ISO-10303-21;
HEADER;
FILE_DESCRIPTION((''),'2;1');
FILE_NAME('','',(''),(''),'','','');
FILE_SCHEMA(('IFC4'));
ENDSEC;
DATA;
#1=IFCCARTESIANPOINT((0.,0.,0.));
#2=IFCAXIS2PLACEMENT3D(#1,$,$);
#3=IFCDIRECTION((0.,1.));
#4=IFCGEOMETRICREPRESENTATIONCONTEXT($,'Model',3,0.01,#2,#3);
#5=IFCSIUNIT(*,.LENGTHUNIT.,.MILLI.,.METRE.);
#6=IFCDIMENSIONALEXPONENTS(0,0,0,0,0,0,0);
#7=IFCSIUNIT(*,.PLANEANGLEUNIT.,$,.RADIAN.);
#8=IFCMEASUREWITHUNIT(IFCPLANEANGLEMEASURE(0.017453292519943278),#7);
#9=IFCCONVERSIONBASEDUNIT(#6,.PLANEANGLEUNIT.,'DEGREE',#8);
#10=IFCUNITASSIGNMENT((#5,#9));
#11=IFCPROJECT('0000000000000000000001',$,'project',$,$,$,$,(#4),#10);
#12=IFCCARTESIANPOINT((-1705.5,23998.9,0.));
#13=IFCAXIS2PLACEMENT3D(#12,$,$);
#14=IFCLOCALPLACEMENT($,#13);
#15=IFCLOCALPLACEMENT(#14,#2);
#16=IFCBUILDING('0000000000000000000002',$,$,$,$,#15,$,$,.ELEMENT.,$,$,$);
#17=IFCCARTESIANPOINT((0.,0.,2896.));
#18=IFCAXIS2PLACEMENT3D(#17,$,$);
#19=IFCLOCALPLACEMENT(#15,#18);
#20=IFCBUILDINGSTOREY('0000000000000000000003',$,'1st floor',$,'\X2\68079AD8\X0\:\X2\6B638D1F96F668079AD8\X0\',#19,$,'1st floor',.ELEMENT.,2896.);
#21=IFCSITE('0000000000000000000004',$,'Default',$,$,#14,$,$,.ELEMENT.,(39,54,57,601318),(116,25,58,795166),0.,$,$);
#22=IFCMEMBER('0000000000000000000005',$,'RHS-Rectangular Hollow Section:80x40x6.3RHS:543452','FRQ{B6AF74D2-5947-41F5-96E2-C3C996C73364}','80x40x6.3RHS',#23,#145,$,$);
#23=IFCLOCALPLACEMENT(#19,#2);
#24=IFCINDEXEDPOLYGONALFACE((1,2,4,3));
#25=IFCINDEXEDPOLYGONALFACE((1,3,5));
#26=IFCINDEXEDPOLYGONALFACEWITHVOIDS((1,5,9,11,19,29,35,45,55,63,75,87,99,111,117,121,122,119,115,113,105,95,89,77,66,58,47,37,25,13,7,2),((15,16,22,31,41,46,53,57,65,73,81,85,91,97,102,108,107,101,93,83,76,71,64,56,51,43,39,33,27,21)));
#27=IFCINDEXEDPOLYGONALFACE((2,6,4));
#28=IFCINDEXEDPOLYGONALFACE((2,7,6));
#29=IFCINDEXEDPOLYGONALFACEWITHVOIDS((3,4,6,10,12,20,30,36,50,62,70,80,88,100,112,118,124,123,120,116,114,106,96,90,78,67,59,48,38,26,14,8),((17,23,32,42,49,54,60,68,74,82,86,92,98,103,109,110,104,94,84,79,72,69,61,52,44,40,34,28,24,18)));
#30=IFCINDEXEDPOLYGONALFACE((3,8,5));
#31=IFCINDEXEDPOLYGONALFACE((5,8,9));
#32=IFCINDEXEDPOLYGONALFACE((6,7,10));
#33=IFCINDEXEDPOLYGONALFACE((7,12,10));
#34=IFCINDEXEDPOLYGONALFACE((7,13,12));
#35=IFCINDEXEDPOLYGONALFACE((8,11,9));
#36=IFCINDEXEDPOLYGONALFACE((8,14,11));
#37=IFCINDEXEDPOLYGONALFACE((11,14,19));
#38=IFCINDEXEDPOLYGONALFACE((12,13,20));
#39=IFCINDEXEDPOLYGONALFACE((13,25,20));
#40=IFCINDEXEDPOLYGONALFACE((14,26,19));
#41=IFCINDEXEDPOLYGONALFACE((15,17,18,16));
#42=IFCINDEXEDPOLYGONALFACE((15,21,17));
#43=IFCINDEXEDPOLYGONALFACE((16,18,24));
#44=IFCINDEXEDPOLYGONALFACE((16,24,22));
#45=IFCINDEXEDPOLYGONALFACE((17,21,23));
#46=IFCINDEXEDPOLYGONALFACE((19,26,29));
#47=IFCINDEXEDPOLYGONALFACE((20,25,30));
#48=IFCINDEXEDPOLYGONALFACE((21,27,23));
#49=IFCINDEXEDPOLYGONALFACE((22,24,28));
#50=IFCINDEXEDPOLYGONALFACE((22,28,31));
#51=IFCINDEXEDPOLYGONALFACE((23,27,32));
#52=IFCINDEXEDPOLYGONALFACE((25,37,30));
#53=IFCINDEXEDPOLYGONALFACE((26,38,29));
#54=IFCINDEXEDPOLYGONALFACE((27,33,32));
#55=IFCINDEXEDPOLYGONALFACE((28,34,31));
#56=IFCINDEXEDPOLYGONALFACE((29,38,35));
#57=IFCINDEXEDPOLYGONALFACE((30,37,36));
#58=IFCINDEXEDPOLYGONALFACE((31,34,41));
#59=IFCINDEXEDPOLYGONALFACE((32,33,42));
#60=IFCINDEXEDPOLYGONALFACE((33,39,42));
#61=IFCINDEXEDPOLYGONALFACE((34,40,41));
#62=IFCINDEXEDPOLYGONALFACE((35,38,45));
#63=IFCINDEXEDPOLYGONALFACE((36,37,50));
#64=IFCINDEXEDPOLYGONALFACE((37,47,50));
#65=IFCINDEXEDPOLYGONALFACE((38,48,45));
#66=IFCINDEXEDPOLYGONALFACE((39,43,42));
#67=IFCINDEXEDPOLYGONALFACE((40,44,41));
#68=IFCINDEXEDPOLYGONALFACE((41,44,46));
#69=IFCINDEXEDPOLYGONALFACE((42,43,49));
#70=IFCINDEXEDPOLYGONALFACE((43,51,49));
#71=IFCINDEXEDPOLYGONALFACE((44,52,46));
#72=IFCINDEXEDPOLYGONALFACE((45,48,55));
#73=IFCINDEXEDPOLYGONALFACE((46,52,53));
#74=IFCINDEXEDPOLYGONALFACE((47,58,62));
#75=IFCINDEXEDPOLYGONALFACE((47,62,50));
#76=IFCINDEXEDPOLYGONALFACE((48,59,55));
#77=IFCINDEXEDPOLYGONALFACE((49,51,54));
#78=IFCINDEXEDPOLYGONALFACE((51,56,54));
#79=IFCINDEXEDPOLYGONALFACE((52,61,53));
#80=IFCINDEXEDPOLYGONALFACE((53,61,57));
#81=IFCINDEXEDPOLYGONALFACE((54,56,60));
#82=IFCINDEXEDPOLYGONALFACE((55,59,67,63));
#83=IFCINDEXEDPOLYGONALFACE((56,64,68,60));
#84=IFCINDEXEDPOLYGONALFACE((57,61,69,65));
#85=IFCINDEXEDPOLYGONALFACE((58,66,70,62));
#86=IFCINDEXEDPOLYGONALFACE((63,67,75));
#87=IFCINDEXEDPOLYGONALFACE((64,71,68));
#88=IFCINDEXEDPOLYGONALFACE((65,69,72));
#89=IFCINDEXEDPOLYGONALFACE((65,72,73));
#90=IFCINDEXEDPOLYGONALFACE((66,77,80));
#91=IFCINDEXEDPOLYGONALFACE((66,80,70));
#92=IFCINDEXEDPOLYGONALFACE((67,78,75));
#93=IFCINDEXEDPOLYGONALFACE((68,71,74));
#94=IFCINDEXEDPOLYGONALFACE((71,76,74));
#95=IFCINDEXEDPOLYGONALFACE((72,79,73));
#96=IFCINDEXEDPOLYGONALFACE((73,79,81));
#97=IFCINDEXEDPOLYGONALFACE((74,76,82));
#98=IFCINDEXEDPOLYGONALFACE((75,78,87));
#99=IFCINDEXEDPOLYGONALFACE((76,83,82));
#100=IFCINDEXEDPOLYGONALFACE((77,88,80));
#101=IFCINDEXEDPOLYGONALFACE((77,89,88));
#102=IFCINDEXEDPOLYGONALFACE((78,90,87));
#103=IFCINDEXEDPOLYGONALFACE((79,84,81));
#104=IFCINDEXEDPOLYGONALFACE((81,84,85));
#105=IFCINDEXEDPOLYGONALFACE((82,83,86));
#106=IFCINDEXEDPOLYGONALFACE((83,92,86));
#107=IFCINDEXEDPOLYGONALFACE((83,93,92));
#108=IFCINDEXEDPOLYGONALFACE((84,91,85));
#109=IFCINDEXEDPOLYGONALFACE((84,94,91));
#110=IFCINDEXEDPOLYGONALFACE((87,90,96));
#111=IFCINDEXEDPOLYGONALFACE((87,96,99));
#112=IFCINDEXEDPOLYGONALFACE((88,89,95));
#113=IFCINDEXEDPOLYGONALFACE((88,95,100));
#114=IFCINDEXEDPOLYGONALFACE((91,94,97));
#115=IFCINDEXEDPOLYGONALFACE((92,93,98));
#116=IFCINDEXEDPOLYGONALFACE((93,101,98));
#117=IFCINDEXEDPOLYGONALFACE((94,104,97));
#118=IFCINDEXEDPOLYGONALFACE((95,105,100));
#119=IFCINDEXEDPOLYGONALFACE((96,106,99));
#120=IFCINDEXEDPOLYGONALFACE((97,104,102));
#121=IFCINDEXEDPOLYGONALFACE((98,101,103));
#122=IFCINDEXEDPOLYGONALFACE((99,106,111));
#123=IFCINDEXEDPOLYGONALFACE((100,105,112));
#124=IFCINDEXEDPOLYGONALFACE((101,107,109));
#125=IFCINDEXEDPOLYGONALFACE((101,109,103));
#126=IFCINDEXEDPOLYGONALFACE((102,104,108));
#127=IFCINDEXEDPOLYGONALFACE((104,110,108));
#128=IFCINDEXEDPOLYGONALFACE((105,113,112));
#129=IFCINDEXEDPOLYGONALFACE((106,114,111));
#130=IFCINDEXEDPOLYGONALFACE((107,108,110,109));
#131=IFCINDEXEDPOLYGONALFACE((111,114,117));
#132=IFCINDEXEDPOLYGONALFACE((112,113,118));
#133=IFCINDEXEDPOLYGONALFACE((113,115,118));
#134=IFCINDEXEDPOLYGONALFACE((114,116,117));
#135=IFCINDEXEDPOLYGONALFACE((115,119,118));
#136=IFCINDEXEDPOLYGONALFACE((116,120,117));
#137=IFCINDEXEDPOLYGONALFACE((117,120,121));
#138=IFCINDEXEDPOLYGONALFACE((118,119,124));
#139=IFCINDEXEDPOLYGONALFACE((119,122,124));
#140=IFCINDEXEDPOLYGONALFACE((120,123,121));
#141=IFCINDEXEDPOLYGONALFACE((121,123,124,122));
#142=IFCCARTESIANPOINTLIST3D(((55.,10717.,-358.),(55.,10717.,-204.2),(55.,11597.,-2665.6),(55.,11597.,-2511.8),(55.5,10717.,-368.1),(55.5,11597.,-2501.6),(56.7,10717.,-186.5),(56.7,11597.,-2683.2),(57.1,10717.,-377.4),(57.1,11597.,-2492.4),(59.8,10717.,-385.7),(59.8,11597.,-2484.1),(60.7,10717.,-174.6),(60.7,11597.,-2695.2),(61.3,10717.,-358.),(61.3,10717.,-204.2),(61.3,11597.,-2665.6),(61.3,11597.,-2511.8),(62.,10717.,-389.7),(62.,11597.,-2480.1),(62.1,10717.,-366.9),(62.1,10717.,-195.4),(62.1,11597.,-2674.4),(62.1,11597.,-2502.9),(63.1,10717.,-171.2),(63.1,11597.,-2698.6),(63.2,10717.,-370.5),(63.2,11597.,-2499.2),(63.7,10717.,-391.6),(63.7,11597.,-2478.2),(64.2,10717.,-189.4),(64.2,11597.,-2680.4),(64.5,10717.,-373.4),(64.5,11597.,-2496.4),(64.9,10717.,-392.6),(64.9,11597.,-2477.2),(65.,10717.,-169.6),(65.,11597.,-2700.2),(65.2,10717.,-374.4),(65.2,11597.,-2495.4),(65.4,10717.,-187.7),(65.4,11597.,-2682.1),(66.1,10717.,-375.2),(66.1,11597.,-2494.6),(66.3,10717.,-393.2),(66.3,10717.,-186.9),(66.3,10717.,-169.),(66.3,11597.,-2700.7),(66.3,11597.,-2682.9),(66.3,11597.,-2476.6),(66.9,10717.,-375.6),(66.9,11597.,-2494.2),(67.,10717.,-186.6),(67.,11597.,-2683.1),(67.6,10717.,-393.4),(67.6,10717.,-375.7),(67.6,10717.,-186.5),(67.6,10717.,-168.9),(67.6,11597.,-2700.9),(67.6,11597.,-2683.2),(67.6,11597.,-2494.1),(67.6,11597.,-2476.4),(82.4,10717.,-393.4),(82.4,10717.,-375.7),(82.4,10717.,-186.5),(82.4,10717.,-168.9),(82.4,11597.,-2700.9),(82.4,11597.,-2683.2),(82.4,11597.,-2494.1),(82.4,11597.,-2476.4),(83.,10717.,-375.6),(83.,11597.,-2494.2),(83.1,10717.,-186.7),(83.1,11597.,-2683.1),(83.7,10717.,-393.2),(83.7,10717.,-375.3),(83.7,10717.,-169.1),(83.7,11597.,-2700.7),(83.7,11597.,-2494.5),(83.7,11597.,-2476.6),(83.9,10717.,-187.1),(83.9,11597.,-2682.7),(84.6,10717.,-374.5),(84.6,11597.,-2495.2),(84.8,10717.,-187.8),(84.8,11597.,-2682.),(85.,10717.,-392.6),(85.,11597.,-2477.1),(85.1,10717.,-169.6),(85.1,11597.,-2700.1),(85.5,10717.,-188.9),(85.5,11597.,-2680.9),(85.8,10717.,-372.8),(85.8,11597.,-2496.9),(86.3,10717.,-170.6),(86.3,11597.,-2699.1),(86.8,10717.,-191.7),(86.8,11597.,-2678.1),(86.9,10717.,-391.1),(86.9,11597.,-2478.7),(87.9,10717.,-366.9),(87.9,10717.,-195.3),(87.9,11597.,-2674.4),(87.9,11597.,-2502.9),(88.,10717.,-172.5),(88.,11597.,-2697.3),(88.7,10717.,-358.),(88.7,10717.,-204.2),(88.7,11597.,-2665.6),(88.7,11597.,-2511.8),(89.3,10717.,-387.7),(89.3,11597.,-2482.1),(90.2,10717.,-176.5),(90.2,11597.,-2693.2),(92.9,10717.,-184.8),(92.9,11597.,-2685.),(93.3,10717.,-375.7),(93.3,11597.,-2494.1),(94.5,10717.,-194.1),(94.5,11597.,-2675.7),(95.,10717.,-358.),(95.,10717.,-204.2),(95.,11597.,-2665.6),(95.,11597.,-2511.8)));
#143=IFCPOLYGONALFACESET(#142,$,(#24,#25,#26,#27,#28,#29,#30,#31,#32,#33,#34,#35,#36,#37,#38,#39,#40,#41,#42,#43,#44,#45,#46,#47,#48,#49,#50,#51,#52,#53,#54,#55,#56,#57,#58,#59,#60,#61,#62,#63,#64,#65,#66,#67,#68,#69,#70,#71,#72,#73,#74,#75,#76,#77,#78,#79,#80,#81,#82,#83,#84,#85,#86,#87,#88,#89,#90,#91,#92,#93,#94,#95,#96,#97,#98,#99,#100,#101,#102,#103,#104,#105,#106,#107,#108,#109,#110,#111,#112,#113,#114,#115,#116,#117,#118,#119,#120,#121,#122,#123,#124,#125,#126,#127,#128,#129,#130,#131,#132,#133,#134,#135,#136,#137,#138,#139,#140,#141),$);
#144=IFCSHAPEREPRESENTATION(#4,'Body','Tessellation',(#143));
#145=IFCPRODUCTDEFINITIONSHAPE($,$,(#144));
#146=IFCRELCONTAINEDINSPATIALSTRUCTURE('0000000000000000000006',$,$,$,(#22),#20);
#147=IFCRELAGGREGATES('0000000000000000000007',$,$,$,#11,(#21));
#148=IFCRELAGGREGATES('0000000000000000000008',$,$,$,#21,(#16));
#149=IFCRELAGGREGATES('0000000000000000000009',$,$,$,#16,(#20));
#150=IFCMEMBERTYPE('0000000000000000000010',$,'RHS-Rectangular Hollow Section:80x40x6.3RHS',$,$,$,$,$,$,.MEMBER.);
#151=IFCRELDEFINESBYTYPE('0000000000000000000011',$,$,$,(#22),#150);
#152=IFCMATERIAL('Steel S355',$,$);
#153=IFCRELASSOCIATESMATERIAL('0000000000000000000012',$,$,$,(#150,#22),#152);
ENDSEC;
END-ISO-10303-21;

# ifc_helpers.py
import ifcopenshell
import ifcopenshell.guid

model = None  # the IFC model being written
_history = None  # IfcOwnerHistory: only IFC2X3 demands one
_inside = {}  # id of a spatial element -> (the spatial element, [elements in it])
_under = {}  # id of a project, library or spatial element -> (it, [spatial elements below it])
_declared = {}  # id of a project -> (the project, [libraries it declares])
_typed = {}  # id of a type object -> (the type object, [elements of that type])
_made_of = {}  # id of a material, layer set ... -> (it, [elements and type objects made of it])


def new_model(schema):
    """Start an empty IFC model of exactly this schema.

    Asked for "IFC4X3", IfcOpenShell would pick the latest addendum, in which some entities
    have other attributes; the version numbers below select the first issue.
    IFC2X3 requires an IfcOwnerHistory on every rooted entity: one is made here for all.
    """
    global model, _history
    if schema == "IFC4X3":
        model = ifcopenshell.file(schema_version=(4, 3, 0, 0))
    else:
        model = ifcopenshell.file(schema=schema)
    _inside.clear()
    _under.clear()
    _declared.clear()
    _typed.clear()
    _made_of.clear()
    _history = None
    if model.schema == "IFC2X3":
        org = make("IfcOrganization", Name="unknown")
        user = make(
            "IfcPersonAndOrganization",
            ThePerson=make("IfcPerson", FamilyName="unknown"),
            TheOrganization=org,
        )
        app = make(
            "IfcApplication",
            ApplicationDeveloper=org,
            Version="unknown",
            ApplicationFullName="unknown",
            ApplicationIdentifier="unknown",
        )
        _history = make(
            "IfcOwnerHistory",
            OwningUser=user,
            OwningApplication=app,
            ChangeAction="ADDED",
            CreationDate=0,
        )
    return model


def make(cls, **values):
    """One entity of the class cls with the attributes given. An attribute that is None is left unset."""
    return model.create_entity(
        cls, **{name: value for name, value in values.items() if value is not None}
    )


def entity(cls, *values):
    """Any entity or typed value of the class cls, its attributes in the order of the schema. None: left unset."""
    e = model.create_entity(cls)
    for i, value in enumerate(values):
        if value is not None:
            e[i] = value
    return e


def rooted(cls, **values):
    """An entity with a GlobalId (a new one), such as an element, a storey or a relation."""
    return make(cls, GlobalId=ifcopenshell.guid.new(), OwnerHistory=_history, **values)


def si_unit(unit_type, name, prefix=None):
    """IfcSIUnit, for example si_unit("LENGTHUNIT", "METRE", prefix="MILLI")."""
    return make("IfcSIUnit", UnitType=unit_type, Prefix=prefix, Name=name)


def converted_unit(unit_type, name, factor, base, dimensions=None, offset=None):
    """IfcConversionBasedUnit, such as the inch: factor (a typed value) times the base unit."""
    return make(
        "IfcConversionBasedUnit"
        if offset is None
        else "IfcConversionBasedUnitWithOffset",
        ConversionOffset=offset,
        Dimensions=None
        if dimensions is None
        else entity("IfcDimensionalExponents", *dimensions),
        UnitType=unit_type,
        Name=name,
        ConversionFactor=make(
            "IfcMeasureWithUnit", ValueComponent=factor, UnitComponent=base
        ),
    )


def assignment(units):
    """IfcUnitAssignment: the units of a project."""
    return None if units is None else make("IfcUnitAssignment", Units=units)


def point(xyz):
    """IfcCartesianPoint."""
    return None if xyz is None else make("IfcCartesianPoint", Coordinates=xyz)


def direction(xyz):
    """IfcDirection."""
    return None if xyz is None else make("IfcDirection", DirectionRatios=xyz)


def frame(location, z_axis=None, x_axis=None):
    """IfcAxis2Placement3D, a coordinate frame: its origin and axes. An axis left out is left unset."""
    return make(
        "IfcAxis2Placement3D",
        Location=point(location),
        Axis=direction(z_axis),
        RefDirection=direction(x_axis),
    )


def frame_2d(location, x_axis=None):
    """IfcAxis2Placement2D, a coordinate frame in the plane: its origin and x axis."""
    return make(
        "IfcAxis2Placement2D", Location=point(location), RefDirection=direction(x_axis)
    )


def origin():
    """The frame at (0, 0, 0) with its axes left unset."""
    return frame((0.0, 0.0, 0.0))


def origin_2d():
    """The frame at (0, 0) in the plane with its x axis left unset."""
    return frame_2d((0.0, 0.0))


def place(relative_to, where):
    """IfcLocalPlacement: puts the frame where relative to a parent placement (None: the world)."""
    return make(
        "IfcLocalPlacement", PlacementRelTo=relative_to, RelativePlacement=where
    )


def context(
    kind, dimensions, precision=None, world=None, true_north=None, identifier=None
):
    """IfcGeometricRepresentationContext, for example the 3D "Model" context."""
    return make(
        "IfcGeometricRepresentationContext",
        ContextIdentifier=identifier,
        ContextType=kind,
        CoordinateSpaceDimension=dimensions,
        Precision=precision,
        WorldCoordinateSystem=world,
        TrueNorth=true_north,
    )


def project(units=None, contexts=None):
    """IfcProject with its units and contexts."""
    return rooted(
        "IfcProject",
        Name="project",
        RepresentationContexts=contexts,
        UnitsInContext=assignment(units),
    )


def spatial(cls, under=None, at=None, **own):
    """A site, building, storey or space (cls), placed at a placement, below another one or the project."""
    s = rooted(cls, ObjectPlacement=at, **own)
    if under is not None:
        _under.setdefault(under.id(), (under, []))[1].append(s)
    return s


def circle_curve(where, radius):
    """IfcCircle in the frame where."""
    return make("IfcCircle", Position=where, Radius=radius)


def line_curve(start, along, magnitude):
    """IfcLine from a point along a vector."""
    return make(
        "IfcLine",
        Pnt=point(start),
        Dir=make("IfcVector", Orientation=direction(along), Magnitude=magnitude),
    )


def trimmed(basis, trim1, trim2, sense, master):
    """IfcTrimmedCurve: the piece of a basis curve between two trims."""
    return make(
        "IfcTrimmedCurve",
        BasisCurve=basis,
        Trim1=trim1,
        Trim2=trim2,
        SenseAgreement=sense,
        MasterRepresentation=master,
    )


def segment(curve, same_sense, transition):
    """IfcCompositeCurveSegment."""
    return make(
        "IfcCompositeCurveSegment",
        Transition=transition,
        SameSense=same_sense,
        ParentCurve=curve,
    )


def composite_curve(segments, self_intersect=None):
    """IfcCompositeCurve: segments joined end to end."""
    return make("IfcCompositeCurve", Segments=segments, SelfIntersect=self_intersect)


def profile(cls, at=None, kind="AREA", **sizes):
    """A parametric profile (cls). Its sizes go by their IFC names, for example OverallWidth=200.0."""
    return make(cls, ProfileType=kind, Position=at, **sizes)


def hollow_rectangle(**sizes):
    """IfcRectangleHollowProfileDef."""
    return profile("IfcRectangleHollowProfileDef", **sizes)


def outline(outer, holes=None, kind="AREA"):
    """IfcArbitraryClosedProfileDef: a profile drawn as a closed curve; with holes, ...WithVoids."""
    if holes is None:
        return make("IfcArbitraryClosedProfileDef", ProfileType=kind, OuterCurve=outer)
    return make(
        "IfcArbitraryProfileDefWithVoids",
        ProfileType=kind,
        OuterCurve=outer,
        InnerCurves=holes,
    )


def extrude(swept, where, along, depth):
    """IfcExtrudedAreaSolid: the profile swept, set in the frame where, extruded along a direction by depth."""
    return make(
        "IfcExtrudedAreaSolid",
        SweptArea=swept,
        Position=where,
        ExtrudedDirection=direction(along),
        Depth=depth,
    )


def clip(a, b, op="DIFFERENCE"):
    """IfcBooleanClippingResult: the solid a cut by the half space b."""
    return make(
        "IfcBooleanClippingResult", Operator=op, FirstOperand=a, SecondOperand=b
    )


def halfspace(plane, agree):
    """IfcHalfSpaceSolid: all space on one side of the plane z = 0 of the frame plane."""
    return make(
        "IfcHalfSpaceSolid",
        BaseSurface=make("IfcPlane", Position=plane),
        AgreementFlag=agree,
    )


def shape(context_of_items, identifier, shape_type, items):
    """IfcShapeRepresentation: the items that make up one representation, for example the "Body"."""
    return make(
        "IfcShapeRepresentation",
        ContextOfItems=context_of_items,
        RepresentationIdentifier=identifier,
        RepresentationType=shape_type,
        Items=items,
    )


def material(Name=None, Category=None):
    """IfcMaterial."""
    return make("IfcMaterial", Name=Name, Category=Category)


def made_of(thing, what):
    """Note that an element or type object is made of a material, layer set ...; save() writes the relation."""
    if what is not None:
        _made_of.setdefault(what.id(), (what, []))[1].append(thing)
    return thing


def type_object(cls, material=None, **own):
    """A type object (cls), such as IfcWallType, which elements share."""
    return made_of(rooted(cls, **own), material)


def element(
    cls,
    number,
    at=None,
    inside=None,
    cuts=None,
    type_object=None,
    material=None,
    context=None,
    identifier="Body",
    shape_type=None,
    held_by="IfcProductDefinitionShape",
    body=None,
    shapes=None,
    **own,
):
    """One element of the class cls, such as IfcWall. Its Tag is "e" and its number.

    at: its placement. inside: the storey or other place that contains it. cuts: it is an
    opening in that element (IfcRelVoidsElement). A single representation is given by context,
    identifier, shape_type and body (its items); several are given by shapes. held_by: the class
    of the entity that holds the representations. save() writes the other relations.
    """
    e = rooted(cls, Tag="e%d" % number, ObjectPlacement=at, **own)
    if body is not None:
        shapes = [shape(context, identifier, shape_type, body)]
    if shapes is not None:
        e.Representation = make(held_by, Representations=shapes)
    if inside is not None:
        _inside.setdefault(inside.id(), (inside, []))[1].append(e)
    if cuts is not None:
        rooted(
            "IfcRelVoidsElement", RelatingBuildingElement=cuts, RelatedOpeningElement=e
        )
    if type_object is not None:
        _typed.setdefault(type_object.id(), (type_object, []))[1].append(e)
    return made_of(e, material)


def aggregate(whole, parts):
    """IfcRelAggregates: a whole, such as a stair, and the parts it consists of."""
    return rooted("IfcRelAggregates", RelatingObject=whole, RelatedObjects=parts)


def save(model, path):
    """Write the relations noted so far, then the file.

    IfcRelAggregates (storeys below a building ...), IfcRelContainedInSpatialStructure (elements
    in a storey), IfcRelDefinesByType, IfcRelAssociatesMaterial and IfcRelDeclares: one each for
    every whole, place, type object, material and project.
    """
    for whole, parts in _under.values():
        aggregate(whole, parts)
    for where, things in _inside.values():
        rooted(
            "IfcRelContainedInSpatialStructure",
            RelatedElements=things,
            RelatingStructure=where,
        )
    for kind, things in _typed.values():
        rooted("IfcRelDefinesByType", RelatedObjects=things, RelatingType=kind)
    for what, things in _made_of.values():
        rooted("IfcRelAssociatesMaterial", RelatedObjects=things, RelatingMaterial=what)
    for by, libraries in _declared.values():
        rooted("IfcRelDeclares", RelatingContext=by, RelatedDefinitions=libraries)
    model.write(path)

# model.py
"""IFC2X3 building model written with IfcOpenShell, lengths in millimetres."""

from ifc_helpers import new_model, entity, si_unit, converted_unit, point, direction, frame, frame_2d, origin, origin_2d, place, context, project, spatial, circle_curve, line_curve, trimmed, segment, composite_curve, hollow_rectangle, outline, extrude, clip, halfspace, material, type_object, element, save


model = new_model("IFC2X3")

# Units and contexts
model_context = context("Model", 3, precision=0.01, world=origin(), true_north=direction((0.0, 1.0)))
ifc_project = project(units=[si_unit("LENGTHUNIT", "METRE", prefix="MILLI"), converted_unit("PLANEANGLEUNIT", "DEGREE", entity("IfcPlaneAngleMeasure", 0.017453292519943278), si_unit("PLANEANGLEUNIT", "RADIAN"), dimensions=[0, 0, 0, 0, 0, 0, 0])], contexts=[model_context])

# Site, building, storey
site_placement = place(None, frame((-1705.5, 23998.9, 0.0)))
site = spatial("IfcSite", under=ifc_project, at=site_placement, Name="Default", CompositionType="ELEMENT", RefLatitude=(39, 54, 57, 601318), RefLongitude=(116, 25, 58, 795166), RefElevation=0.0)
building_placement = place(site_placement, origin())
building = spatial("IfcBuilding", under=site, at=building_placement, CompositionType="ELEMENT")
storey_placement = place(building_placement, frame((0.0, 0.0, 2896.0)))
storey = spatial("IfcBuildingStorey", under=building, at=storey_placement, Name="1st floor", ObjectType="标高:正负零标高", LongName="1st floor", CompositionType="ELEMENT", Elevation=2896.0)

# Shared definitions
ifc_material_1 = material(Name="Steel S355")

# Member, opening
member_type = type_object("IfcMemberType", Name="RHS-Rectangular Hollow Section:80x40x6.3RHS", PredefinedType="MEMBER", material=ifc_material_1)
member_1_placement = place(storey_placement, frame((75.0, 11701.7, -2863.3), z_axis=(0.0, 0.356325, -0.934362), x_axis=(-1.0, 0.0, 0.0)))
member_1 = element("IfcMember", 1, at=member_1_placement, inside=storey, type_object=member_type, material=ifc_material_1, Name="RHS-Rectangular Hollow Section:80x40x6.3RHS:543452", Description="FRQ{B6AF74D2-5947-41F5-96E2-C3C996C73364}", ObjectType="80x40x6.3RHS", context=model_context, shape_type="Clipping", body=[
    clip(clip(clip(extrude(hollow_rectangle(XDim=40.0, YDim=80.0, WallThickness=6.3, InnerFilletRadius=6.3, OuterFilletRadius=12.6, at=origin_2d()), origin(), (0.0, 0.0, -1.0), 3029.4), halfspace(frame((75.0, -109.5, -6.7), z_axis=(0.0, -0.934362, -0.356325), x_axis=(-1.0, 0.0, 0.0)), True)), halfspace(frame((75.0, -931.7, -320.3), z_axis=(0.0, 0.934362, 0.356325), x_axis=(1.0, 0.0, 0.0)), True)), halfspace(frame((75.0, -53.4, 14.6), z_axis=(0.0, -0.934362, -0.356325), x_axis=(-1.0, 0.0, 0.0)), True)),
])
opening_1_placement = place(member_1_placement, frame((0.0, -19.6, -74.1), z_axis=(0.0, 0.356325, -0.934362), x_axis=(-1.0, 0.0, 0.0)))
element("IfcOpeningElement", 2, at=opening_1_placement, cuts=member_1, ObjectType="Opening", context=model_context, shape_type="SweptSolid", body=[
    extrude(outline(composite_curve([segment(trimmed(circle_curve(frame_2d((-40.0, -40.0), x_axis=(1.0, 0.0)), 20.0), [point((-60.0, -40.0))], [point((-40.0, -60.0))], True, "CARTESIAN"), True, "CONTINUOUS"), segment(trimmed(line_curve((-40.0, -60.0), (1.0, 0.0), 80.000001), [point((-40.0, -60.0))], [point((40.0, -60.0))], True, "CARTESIAN"), True, "CONTINUOUS"), segment(trimmed(circle_curve(frame_2d((40.0, -40.0), x_axis=(1.0, 0.0)), 20.0), [point((40.0, -60.0))], [point((60.0, -40.0))], True, "CARTESIAN"), True, "CONTINUOUS"), segment(trimmed(line_curve((60.0, -40.0), (0.0, 1.0), 79.999999), [point((60.0, -40.0))], [point((60.0, 40.0))], True, "CARTESIAN"), True, "CONTINUOUS"), segment(trimmed(circle_curve(frame_2d((40.0, 40.0), x_axis=(1.0, 0.0)), 20.0), [point((60.0, 40.0))], [point((40.0, 60.0))], True, "CARTESIAN"), True, "CONTINUOUS"), segment(trimmed(line_curve((40.0, 60.0), (-1.0, 0.0), 80.0), [point((40.0, 60.0))], [point((-40.0, 60.0))], True, "CARTESIAN"), True, "CONTINUOUS"), segment(trimmed(circle_curve(frame_2d((-40.0, 40.0), x_axis=(1.0, 0.0)), 20.0), [point((-40.0, 60.0))], [point((-60.0, 40.0))], True, "CARTESIAN"), True, "CONTINUOUS"), segment(trimmed(line_curve((-60.0, 40.0), (0.0, -1.0), 80.0), [point((-60.0, 40.0))], [point((-60.0, -40.0))], True, "CARTESIAN"), True, "CONTINUOUS")], self_intersect="UNKNOWN")), origin(), (0.0, 0.0, 1.0), 2732.3),
])

save(model, "model.ifc")
